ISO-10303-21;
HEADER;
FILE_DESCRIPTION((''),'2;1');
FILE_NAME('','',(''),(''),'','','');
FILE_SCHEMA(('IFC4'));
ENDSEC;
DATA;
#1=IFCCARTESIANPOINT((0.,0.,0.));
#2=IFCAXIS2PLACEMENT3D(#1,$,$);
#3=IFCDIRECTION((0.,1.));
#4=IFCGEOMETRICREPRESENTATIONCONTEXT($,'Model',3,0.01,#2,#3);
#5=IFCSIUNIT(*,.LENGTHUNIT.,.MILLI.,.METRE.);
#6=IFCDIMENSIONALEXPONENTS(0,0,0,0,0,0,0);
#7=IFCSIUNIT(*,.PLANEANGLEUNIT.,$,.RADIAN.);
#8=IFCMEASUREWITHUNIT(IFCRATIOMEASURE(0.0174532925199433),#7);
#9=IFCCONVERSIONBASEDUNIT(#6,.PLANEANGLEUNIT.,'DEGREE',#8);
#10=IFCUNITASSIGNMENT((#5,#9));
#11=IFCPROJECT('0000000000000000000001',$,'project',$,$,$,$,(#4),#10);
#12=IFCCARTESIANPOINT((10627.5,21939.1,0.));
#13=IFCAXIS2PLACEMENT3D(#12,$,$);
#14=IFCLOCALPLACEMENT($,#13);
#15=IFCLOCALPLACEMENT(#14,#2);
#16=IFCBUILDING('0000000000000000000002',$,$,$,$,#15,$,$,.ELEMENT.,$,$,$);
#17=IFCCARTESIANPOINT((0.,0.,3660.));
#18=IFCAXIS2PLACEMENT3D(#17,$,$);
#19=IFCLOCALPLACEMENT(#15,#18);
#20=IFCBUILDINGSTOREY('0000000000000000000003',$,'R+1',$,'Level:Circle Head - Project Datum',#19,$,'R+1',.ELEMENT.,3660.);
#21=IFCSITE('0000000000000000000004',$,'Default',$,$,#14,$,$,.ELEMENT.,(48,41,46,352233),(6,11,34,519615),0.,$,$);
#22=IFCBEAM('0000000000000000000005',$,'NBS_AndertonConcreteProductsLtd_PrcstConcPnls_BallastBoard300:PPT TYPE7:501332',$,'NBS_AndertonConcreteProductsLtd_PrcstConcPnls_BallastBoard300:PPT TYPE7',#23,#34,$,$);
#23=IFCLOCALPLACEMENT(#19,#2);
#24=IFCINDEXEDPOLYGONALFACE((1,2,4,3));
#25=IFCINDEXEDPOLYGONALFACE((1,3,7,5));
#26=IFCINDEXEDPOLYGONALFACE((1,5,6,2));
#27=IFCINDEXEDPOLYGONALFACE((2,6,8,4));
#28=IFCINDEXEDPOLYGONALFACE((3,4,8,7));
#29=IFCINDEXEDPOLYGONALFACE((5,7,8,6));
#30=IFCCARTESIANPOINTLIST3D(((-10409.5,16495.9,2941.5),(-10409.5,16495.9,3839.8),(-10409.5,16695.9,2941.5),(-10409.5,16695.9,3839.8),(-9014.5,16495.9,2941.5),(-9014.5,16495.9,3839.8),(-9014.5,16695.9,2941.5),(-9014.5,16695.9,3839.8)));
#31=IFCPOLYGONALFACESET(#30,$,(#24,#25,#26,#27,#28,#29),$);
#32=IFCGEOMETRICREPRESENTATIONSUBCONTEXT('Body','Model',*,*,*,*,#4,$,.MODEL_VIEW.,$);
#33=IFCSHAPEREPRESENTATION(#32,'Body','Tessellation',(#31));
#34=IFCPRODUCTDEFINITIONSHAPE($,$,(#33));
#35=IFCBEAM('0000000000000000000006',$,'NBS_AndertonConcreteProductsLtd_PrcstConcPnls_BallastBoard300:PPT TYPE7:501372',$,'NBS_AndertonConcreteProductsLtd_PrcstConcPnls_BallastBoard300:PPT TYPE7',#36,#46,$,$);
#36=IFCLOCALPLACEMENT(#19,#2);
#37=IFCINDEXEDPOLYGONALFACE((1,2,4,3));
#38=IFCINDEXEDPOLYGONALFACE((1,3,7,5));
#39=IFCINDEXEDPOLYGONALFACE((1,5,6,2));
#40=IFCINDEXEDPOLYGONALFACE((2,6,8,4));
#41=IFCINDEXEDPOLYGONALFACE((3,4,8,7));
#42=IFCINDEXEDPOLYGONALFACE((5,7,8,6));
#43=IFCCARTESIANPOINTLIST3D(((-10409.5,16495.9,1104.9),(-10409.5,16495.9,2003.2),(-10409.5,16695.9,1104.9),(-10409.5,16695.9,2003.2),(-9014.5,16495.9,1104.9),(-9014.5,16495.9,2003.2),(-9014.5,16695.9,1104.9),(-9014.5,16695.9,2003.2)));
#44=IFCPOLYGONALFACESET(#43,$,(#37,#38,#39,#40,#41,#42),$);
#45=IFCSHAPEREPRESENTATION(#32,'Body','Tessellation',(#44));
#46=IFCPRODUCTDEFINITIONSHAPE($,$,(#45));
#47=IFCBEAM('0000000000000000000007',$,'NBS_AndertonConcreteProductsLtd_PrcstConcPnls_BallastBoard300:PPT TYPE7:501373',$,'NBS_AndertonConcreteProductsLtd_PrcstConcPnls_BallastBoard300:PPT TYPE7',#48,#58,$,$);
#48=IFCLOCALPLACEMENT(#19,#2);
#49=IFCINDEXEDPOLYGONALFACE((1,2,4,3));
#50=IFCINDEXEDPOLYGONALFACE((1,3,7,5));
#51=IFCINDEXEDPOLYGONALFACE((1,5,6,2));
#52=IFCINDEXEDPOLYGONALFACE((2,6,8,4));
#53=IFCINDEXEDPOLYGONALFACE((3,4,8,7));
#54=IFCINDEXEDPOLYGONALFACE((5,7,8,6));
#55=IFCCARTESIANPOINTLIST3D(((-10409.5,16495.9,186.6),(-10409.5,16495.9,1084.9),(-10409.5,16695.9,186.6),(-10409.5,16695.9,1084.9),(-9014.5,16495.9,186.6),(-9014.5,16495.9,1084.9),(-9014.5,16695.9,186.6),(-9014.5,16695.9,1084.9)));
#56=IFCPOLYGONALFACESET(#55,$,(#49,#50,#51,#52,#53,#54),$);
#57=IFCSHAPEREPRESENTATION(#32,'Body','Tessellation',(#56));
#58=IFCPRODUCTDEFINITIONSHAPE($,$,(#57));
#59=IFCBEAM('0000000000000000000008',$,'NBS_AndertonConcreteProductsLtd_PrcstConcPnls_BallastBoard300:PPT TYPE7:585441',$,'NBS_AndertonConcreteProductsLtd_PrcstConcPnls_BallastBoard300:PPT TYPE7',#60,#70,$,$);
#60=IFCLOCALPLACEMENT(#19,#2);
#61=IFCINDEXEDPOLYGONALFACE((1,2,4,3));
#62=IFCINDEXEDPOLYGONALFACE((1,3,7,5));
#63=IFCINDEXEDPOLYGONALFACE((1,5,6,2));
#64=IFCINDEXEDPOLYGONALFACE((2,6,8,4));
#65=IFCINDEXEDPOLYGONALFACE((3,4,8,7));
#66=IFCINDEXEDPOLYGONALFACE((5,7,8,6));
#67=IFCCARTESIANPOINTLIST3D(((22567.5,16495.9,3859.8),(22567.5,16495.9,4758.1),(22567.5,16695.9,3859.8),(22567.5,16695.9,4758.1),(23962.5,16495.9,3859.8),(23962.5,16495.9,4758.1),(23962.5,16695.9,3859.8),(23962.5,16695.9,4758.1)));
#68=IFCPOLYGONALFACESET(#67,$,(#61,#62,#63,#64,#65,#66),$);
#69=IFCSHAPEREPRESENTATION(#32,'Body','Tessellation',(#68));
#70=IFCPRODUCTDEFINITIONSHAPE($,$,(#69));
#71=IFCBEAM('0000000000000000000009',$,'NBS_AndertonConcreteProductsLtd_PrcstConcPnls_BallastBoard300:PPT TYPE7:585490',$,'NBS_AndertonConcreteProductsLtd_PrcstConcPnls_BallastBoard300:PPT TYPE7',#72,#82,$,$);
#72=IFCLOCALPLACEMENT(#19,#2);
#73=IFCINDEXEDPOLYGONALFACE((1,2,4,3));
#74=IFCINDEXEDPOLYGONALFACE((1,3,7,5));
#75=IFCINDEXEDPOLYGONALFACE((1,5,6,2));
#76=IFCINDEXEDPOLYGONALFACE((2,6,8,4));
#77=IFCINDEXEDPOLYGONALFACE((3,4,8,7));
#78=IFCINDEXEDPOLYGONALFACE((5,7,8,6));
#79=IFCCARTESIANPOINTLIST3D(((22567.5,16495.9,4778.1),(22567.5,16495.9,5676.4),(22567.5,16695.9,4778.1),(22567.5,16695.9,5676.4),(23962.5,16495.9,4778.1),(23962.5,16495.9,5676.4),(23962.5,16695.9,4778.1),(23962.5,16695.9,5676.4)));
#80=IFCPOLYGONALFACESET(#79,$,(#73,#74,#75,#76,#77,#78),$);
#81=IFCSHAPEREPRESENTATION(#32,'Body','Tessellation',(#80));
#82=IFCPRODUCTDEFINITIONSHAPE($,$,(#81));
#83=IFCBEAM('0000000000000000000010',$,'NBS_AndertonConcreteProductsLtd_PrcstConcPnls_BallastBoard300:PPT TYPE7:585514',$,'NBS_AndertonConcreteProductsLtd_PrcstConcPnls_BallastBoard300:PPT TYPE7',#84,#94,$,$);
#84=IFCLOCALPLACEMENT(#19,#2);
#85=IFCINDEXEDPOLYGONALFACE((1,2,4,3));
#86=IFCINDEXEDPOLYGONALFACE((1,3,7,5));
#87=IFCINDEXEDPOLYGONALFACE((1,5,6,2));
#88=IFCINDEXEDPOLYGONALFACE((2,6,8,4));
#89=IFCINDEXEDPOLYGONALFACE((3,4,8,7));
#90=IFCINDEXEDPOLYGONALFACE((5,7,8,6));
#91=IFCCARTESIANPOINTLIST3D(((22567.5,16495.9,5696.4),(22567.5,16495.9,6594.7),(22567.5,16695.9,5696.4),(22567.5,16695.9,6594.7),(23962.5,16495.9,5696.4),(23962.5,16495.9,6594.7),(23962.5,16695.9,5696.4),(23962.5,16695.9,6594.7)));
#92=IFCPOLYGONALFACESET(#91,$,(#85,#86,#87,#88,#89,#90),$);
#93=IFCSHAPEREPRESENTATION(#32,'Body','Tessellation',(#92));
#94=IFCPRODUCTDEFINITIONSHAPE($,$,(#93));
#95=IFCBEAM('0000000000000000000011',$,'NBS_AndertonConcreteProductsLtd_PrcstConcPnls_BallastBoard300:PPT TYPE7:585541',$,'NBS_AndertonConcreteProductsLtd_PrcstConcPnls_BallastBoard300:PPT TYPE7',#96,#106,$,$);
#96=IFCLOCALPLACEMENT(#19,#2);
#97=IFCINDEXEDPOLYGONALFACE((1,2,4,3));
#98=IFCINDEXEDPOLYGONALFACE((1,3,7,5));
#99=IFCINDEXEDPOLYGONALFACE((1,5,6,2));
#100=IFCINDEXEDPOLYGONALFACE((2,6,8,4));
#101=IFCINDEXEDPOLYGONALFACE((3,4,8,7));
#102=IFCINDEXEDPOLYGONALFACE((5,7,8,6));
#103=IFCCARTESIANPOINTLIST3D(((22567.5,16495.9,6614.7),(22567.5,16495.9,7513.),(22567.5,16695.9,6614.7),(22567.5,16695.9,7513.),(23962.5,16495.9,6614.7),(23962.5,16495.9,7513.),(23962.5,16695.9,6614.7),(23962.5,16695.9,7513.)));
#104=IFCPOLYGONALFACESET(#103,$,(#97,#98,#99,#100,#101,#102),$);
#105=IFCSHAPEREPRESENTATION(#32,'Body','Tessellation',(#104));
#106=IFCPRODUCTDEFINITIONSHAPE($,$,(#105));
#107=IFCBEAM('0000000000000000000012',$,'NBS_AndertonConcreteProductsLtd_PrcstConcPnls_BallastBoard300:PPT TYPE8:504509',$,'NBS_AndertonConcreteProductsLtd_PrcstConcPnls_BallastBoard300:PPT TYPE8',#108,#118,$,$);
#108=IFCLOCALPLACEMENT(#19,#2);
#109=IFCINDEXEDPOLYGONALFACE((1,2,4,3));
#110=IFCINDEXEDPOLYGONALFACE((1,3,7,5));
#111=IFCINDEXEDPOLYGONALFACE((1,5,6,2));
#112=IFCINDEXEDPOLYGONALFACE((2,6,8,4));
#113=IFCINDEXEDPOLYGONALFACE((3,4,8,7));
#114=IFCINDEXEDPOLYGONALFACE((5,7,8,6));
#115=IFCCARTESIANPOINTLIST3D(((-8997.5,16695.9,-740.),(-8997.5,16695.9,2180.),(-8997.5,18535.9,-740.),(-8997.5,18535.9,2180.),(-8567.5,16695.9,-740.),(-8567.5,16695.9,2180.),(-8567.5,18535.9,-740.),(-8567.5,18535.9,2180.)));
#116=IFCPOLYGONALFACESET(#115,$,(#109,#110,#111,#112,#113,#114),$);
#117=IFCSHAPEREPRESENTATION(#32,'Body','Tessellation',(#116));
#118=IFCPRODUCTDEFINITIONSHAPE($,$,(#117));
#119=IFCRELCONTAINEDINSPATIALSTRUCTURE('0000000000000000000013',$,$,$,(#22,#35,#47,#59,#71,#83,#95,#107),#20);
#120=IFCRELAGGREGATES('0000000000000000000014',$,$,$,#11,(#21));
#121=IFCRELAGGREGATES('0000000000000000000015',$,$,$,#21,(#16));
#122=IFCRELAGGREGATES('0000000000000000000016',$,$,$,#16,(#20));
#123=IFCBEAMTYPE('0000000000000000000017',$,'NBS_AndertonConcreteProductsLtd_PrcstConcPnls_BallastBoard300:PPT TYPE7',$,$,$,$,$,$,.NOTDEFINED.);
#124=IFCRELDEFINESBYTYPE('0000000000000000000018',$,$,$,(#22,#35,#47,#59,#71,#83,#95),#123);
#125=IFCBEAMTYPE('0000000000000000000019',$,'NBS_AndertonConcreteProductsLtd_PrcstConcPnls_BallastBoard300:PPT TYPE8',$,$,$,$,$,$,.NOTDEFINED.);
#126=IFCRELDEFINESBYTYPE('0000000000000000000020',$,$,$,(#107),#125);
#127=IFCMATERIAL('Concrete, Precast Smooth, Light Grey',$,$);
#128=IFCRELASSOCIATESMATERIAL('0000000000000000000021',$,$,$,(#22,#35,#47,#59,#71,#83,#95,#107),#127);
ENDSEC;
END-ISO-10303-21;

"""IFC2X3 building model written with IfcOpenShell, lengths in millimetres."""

from ifc_helpers import new_model, entity, si_unit, converted_unit, direction, frame, frame_2d, origin, place, context, subcontext, project, spatial, rectangle, extrude, material, type_object, element, save


model = new_model("IFC2X3")

# Units and contexts
model_context = context("Model", 3, precision=0.01, world=origin(), true_north=direction((0.0, 1.0)))
body_context = subcontext(model_context, "Body", "Model", "MODEL_VIEW")
ifc_project = project(units=[si_unit("LENGTHUNIT", "METRE", prefix="MILLI"), converted_unit("PLANEANGLEUNIT", "DEGREE", entity("IfcRatioMeasure", 0.0174532925199433), si_unit("PLANEANGLEUNIT", "RADIAN"), dimensions=[0, 0, 0, 0, 0, 0, 0])], contexts=[model_context])

# Site, building, storey
site_placement = place(None, frame((10627.5, 21939.1, 0.0)))
site = spatial("IfcSite", under=ifc_project, at=site_placement, Name="Default", CompositionType="ELEMENT", RefLatitude=(48, 41, 46, 352233), RefLongitude=(6, 11, 34, 519615), RefElevation=0.0)
building_placement = place(site_placement, origin())
building = spatial("IfcBuilding", under=site, at=building_placement, CompositionType="ELEMENT")
storey_placement = place(building_placement, frame((0.0, 0.0, 3660.0)))
storey = spatial("IfcBuildingStorey", under=building, at=storey_placement, Name="R+1", ObjectType="Level:Circle Head - Project Datum", LongName="R+1", CompositionType="ELEMENT", Elevation=3660.0)

# Beams
ifc_material = material(Name="Concrete, Precast Smooth, Light Grey")
beam_type_1 = type_object("IfcBeamType", Name="NBS_AndertonConcreteProductsLtd_PrcstConcPnls_BallastBoard300:PPT TYPE7", PredefinedType="NOTDEFINED")
beam_1_placement = place(storey_placement, origin())
element("IfcBeam", 1, at=beam_1_placement, inside=storey, type_object=beam_type_1, material=ifc_material, Name="NBS_AndertonConcreteProductsLtd_PrcstConcPnls_BallastBoard300:PPT TYPE7:501332", ObjectType="NBS_AndertonConcreteProductsLtd_PrcstConcPnls_BallastBoard300:PPT TYPE7", context=body_context, shape_type="SweptSolid", body=[
    extrude(rectangle(XDim=898.3, YDim=200.0, at=frame_2d((0.0, 0.0), x_axis=(0.0, 1.0))), frame((-10409.5, 16595.9, 3390.7), z_axis=(1.0, 0.0, 0.0), x_axis=(0.0, 1.0, 0.0)), (0.0, 0.0, 1.0), 1395.0),
])
beam_2_placement = place(storey_placement, origin())
element("IfcBeam", 2, at=beam_2_placement, inside=storey, type_object=beam_type_1, material=ifc_material, Name="NBS_AndertonConcreteProductsLtd_PrcstConcPnls_BallastBoard300:PPT TYPE7:501372", ObjectType="NBS_AndertonConcreteProductsLtd_PrcstConcPnls_BallastBoard300:PPT TYPE7", context=body_context, shape_type="SweptSolid", body=[
    extrude(rectangle(XDim=898.3, YDim=200.0, at=frame_2d((0.0, 0.0), x_axis=(0.0, 1.0))), frame((-10409.5, 16595.9, 1554.0), z_axis=(1.0, 0.0, 0.0), x_axis=(0.0, 1.0, 0.0)), (0.0, 0.0, 1.0), 1395.0),
])
beam_3_placement = place(storey_placement, origin())
element("IfcBeam", 3, at=beam_3_placement, inside=storey, type_object=beam_type_1, material=ifc_material, Name="NBS_AndertonConcreteProductsLtd_PrcstConcPnls_BallastBoard300:PPT TYPE7:501373", ObjectType="NBS_AndertonConcreteProductsLtd_PrcstConcPnls_BallastBoard300:PPT TYPE7", context=body_context, shape_type="SweptSolid", body=[
    extrude(rectangle(XDim=898.3, YDim=200.0, at=frame_2d((0.0, 0.0), x_axis=(0.0, 1.0))), frame((-10409.5, 16595.9, 635.7), z_axis=(1.0, 0.0, 0.0), x_axis=(0.0, 1.0, 0.0)), (0.0, 0.0, 1.0), 1395.0),
])
beam_4_placement = place(storey_placement, origin())
element("IfcBeam", 4, at=beam_4_placement, inside=storey, type_object=beam_type_1, material=ifc_material, Name="NBS_AndertonConcreteProductsLtd_PrcstConcPnls_BallastBoard300:PPT TYPE7:585441", ObjectType="NBS_AndertonConcreteProductsLtd_PrcstConcPnls_BallastBoard300:PPT TYPE7", context=body_context, shape_type="SweptSolid", body=[
    extrude(rectangle(XDim=898.3, YDim=200.0, at=frame_2d((0.0, 0.0), x_axis=(0.0, 1.0))), frame((22567.5, 16595.9, 4309.0), z_axis=(1.0, 0.0, 0.0), x_axis=(0.0, 1.0, 0.0)), (0.0, 0.0, 1.0), 1395.0),
])
beam_5_placement = place(storey_placement, origin())
element("IfcBeam", 5, at=beam_5_placement, inside=storey, type_object=beam_type_1, material=ifc_material, Name="NBS_AndertonConcreteProductsLtd_PrcstConcPnls_BallastBoard300:PPT TYPE7:585490", ObjectType="NBS_AndertonConcreteProductsLtd_PrcstConcPnls_BallastBoard300:PPT TYPE7", context=body_context, shape_type="SweptSolid", body=[
    extrude(rectangle(XDim=898.3, YDim=200.0, at=frame_2d((0.0, 0.0), x_axis=(0.0, 1.0))), frame((22567.5, 16595.9, 5227.3), z_axis=(1.0, 0.0, 0.0), x_axis=(0.0, 1.0, 0.0)), (0.0, 0.0, 1.0), 1395.0),
])
beam_6_placement = place(storey_placement, origin())
element("IfcBeam", 6, at=beam_6_placement, inside=storey, type_object=beam_type_1, material=ifc_material, Name="NBS_AndertonConcreteProductsLtd_PrcstConcPnls_BallastBoard300:PPT TYPE7:585514", ObjectType="NBS_AndertonConcreteProductsLtd_PrcstConcPnls_BallastBoard300:PPT TYPE7", context=body_context, shape_type="SweptSolid", body=[
    extrude(rectangle(XDim=898.3, YDim=200.0, at=frame_2d((0.0, 0.0), x_axis=(0.0, 1.0))), frame((22567.5, 16595.9, 6145.6), z_axis=(1.0, 0.0, 0.0), x_axis=(0.0, 1.0, 0.0)), (0.0, 0.0, 1.0), 1395.0),
])
beam_7_placement = place(storey_placement, origin())
element("IfcBeam", 7, at=beam_7_placement, inside=storey, type_object=beam_type_1, material=ifc_material, Name="NBS_AndertonConcreteProductsLtd_PrcstConcPnls_BallastBoard300:PPT TYPE7:585541", ObjectType="NBS_AndertonConcreteProductsLtd_PrcstConcPnls_BallastBoard300:PPT TYPE7", context=body_context, shape_type="SweptSolid", body=[
    extrude(rectangle(XDim=898.3, YDim=200.0, at=frame_2d((0.0, 0.0), x_axis=(0.0, 1.0))), frame((22567.5, 16595.9, 7063.9), z_axis=(1.0, 0.0, 0.0), x_axis=(0.0, 1.0, 0.0)), (0.0, 0.0, 1.0), 1395.0),
])
beam_type_2 = type_object("IfcBeamType", Name="NBS_AndertonConcreteProductsLtd_PrcstConcPnls_BallastBoard300:PPT TYPE8", PredefinedType="NOTDEFINED")
beam_8_placement = place(storey_placement, origin())
element("IfcBeam", 8, at=beam_8_placement, inside=storey, type_object=beam_type_2, material=ifc_material, Name="NBS_AndertonConcreteProductsLtd_PrcstConcPnls_BallastBoard300:PPT TYPE8:504509", ObjectType="NBS_AndertonConcreteProductsLtd_PrcstConcPnls_BallastBoard300:PPT TYPE8", context=body_context, shape_type="SweptSolid", body=[
    extrude(rectangle(XDim=2920.0, YDim=1840.0, at=frame_2d((0.0, 0.0), x_axis=(0.0, 1.0))), frame((-8997.5, 17615.9, 720.0), z_axis=(1.0, 0.0, 0.0), x_axis=(0.0, -1.0, 0.0)), (0.0, 0.0, 1.0), 430.0),
])

save(model, "model.ifc")
